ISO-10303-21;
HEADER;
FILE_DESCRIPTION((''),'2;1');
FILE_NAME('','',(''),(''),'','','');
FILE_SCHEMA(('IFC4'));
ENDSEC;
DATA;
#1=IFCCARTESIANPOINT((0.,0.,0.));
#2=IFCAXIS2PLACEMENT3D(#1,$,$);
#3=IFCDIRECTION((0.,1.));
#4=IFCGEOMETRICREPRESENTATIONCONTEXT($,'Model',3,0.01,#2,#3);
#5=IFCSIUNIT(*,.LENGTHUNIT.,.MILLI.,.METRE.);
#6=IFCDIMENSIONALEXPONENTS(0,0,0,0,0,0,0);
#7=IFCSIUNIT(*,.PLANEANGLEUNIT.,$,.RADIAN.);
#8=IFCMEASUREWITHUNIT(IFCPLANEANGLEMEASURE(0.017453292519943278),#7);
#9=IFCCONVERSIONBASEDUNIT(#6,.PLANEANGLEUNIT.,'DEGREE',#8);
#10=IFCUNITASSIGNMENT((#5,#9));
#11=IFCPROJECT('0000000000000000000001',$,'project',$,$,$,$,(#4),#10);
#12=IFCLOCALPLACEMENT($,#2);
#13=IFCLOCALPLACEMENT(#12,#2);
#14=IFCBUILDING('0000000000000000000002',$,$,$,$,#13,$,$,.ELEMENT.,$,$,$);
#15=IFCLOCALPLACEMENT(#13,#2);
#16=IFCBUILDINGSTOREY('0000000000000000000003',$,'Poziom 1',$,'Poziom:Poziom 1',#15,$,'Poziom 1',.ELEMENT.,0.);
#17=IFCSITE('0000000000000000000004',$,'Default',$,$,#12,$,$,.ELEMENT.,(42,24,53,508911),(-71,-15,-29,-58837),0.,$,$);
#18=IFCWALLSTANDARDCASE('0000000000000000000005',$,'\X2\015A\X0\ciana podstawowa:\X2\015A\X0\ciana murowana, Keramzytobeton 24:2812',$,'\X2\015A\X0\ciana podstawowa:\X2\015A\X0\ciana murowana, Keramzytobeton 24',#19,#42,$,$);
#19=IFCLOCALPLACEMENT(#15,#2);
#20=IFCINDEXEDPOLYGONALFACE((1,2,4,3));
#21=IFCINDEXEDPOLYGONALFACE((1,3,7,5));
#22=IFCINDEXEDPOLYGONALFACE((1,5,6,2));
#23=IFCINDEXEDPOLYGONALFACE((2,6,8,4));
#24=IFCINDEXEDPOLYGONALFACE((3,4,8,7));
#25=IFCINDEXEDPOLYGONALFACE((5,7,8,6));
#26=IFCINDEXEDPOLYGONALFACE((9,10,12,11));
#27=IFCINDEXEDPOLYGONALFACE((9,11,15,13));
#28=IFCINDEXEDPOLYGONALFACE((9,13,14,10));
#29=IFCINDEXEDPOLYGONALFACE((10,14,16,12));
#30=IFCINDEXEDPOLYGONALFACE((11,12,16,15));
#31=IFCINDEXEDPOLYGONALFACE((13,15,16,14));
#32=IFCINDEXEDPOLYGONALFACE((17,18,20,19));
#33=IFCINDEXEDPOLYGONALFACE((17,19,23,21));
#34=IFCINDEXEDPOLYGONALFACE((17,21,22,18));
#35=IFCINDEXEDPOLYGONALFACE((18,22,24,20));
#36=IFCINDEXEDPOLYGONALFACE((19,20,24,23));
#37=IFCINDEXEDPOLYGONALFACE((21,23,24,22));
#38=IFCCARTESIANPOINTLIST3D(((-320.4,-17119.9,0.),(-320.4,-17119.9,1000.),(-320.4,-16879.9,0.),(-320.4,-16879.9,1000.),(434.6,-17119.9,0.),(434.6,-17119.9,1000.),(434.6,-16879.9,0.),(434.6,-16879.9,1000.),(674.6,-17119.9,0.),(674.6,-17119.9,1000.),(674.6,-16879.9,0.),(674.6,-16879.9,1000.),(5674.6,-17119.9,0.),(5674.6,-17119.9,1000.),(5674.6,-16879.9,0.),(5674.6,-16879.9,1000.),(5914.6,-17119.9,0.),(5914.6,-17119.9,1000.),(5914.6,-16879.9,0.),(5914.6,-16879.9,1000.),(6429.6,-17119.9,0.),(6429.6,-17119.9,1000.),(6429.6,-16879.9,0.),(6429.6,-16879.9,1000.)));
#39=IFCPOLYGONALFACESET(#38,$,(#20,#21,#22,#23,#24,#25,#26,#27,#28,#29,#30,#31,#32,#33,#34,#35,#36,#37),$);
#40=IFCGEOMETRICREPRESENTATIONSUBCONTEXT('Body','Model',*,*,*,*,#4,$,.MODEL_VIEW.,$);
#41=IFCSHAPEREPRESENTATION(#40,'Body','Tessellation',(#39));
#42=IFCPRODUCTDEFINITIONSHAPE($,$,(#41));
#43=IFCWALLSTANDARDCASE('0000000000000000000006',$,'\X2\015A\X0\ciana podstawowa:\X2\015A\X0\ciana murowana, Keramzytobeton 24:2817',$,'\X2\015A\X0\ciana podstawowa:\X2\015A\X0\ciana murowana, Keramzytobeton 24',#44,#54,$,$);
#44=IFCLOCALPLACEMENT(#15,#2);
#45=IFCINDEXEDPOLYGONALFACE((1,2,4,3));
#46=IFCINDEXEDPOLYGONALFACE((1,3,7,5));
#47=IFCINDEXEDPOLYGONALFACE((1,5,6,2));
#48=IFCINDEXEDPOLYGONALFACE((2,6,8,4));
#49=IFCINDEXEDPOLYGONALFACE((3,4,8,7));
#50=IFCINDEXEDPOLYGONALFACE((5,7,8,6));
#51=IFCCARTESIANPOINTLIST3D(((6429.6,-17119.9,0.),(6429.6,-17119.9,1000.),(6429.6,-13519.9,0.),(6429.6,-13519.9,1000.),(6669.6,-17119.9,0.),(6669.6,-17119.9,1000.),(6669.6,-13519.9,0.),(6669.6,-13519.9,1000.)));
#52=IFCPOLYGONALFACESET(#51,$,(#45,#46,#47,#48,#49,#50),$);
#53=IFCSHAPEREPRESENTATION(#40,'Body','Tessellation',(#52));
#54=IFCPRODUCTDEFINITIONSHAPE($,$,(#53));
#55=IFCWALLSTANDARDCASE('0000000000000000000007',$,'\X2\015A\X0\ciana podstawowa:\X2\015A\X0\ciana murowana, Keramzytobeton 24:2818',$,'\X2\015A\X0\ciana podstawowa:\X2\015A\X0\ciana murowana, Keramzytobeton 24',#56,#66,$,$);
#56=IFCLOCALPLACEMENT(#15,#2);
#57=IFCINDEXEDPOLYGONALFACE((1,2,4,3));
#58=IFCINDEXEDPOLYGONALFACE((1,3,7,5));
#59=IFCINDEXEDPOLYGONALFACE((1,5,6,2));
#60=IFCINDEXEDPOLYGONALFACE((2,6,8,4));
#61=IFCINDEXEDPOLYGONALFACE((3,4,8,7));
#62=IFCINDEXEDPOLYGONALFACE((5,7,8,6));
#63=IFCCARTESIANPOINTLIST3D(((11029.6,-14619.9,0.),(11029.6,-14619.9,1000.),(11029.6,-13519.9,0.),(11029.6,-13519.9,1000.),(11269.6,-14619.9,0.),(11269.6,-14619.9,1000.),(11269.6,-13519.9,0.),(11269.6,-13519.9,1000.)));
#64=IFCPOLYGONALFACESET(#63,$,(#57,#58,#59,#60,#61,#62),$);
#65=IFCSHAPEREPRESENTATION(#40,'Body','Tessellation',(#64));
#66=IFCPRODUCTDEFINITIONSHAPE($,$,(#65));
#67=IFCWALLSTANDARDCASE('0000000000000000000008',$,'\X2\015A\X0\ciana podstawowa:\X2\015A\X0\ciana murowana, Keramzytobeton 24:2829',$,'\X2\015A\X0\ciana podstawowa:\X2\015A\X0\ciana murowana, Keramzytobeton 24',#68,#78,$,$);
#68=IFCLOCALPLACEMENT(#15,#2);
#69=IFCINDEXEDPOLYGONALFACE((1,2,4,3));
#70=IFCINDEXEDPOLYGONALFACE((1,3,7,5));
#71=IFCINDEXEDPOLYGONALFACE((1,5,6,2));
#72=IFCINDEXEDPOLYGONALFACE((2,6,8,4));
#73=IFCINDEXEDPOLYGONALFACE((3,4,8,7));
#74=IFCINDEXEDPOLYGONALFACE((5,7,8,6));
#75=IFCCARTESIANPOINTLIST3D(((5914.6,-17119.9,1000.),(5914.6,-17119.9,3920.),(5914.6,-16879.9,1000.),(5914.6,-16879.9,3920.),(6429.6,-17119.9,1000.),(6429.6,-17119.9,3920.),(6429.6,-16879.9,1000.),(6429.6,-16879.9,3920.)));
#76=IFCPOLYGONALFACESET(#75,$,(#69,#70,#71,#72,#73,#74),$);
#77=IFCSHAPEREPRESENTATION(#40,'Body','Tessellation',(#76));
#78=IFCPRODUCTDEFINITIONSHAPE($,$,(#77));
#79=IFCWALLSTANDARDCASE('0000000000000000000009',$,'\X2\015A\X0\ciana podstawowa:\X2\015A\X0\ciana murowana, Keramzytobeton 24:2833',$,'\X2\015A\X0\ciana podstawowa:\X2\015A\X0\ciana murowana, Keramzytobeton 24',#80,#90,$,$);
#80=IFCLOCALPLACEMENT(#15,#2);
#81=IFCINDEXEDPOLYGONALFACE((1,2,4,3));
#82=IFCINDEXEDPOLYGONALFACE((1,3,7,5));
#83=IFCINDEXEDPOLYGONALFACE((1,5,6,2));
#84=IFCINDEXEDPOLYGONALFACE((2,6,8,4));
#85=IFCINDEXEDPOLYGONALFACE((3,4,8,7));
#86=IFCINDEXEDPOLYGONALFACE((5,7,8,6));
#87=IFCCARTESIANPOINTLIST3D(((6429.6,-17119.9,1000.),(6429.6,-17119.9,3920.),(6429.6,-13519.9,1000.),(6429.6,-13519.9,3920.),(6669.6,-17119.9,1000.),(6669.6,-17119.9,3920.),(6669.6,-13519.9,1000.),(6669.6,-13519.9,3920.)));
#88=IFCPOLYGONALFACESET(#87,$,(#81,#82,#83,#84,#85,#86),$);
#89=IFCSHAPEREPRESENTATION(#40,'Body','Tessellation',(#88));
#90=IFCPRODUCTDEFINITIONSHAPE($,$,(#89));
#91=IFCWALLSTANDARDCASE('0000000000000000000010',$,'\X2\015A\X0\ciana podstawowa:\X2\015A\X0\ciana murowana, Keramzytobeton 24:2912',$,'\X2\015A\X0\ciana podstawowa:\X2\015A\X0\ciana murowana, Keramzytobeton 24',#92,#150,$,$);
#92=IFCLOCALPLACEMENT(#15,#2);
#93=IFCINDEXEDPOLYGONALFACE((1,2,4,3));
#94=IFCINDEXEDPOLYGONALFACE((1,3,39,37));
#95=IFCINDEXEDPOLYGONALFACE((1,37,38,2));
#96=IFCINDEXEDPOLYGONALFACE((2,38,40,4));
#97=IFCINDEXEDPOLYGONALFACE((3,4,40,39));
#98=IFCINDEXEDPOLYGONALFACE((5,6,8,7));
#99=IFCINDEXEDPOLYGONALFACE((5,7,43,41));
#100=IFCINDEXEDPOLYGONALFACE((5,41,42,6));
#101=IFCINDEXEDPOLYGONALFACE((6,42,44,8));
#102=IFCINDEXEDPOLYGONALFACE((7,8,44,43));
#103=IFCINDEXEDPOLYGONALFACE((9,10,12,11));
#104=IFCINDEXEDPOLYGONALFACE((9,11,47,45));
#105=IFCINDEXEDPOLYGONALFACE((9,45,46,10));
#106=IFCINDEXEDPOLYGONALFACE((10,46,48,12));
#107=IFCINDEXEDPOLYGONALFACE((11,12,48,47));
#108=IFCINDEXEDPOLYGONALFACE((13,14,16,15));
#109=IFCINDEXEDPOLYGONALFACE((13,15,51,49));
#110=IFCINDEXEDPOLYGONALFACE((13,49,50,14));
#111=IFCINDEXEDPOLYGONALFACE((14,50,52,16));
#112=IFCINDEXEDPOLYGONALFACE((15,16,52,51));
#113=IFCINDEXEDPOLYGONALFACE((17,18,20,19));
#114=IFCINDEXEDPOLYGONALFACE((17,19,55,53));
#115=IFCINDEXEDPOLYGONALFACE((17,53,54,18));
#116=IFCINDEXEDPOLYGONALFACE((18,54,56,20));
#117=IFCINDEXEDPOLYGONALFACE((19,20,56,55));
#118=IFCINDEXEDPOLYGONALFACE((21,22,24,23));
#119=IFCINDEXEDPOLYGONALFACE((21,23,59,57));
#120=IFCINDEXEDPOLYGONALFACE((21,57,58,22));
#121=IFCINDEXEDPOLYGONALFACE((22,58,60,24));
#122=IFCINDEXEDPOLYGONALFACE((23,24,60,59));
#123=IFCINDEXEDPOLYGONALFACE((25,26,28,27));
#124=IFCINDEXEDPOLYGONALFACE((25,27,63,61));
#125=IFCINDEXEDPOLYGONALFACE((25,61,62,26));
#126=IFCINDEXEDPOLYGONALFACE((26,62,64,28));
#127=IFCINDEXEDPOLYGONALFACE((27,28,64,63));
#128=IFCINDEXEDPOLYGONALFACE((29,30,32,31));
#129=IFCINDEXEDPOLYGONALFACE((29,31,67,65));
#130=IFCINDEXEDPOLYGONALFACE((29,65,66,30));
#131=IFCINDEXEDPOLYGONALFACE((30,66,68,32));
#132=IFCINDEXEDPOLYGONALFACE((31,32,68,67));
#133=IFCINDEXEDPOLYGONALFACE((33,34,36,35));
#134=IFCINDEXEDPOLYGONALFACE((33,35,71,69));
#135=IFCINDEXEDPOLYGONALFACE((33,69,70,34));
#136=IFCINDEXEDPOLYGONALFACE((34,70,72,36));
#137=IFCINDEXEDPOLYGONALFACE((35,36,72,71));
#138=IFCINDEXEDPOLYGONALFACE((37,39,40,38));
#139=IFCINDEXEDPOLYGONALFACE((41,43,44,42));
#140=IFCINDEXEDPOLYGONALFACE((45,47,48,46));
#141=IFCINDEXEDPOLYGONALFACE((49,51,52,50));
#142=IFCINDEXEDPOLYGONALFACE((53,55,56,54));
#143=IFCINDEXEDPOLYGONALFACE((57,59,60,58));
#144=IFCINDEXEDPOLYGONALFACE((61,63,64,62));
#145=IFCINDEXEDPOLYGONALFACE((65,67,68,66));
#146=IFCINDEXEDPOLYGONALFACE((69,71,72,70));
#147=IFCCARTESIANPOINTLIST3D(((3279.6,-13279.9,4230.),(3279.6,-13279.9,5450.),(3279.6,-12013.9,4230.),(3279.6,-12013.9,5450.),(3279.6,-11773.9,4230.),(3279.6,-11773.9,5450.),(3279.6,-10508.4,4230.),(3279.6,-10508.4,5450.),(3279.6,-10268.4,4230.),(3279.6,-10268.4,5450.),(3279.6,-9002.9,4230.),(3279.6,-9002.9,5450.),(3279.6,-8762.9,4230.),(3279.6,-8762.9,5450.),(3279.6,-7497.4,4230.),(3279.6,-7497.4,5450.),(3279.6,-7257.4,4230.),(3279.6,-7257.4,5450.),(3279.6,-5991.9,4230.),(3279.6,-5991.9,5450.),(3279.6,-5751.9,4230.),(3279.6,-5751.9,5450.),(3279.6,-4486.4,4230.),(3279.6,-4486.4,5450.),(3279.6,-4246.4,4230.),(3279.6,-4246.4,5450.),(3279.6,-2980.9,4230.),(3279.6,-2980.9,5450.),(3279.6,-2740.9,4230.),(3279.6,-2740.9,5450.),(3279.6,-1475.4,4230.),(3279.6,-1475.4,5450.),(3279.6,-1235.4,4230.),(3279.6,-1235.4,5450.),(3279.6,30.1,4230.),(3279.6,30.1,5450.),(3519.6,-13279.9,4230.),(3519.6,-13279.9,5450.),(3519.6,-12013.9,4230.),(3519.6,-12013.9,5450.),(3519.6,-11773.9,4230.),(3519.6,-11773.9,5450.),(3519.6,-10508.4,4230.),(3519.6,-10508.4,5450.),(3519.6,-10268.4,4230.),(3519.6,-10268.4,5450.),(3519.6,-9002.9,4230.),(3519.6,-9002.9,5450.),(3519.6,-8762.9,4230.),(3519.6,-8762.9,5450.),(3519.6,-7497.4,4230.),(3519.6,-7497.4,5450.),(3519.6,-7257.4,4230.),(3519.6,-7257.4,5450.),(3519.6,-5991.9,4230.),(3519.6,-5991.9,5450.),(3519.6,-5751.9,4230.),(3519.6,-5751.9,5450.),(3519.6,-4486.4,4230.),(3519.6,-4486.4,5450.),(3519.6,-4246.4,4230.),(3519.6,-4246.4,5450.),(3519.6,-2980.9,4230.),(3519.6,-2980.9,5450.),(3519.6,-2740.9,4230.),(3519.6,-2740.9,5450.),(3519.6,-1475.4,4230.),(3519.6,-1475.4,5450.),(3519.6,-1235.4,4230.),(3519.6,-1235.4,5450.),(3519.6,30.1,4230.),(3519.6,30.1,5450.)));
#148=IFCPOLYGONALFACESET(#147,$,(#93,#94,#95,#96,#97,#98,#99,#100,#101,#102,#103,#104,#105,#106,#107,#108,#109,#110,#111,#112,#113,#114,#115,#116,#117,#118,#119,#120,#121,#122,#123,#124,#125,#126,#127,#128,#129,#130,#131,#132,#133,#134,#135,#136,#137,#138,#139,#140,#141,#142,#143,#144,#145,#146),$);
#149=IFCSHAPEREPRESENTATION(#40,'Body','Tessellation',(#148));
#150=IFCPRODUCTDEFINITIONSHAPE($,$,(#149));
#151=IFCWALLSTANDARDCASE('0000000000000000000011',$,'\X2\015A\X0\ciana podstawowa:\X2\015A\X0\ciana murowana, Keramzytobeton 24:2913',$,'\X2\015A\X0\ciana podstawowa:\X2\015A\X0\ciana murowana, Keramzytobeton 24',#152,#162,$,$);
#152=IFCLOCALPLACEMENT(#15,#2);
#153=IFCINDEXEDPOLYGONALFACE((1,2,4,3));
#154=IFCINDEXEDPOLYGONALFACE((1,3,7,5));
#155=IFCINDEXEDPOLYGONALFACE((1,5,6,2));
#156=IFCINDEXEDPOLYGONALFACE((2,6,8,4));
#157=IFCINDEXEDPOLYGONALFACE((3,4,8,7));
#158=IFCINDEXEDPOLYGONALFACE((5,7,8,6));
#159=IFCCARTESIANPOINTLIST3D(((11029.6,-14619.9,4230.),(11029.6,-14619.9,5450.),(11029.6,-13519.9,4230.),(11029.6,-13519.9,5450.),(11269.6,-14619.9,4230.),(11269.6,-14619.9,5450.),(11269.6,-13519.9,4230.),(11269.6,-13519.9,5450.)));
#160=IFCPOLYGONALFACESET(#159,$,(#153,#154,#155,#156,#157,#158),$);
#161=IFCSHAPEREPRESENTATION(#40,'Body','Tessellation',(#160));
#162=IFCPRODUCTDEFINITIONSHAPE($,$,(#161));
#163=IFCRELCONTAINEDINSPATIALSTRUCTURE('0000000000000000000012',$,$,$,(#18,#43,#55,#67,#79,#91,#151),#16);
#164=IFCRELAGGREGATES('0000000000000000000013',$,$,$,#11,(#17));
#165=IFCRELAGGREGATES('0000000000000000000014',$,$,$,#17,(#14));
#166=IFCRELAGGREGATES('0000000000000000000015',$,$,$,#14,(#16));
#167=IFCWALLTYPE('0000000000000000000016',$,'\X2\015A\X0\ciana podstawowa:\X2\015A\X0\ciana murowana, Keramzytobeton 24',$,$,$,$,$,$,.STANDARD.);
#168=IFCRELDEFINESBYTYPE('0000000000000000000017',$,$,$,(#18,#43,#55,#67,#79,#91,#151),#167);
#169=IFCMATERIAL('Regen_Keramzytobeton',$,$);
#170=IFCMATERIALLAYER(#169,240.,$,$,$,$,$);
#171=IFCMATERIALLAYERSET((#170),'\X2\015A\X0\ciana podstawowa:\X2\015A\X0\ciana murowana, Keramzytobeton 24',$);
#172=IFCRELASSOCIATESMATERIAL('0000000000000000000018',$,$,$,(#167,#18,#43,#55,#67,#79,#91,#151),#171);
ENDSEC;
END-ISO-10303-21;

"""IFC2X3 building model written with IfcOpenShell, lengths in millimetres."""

from ifc_helpers import new_model, entity, si_unit, converted_unit, direction, frame, frame_2d, origin, place, context, subcontext, project, spatial, rectangle, extrude, material, layer, layer_set, layer_usage, type_object, element, save


model = new_model("IFC2X3")

# Units and contexts
model_context = context("Model", 3, precision=0.01, world=origin(), true_north=direction((0.0, 1.0)))
body_context = subcontext(model_context, "Body", "Model", "MODEL_VIEW")
ifc_project = project(units=[si_unit("LENGTHUNIT", "METRE", prefix="MILLI"), converted_unit("PLANEANGLEUNIT", "DEGREE", entity("IfcPlaneAngleMeasure", 0.017453292519943278), si_unit("PLANEANGLEUNIT", "RADIAN"), dimensions=[0, 0, 0, 0, 0, 0, 0])], contexts=[model_context])

# Site, building, storey
site_placement = place(None, origin())
site = spatial("IfcSite", under=ifc_project, at=site_placement, Name="Default", CompositionType="ELEMENT", RefLatitude=(42, 24, 53, 508911), RefLongitude=(-71, -15, -29, -58837), RefElevation=0.0)
building_placement = place(site_placement, origin())
building = spatial("IfcBuilding", under=site, at=building_placement, CompositionType="ELEMENT")
storey_placement = place(building_placement, origin())
storey = spatial("IfcBuildingStorey", under=building, at=storey_placement, Name="Poziom 1", ObjectType="Poziom:Poziom 1", LongName="Poziom 1", CompositionType="ELEMENT", Elevation=0.0)

# Shared definitions
ifc_material_1 = material(Name="Regen_Keramzytobeton")
ifc_layer_1 = layer(ifc_material_1, 240.0)
ifc_layer_set_1 = layer_set([ifc_layer_1], Name="Ściana podstawowa:Ściana murowana, Keramzytobeton 24")
wall_type_1 = type_object("IfcWallType", Name="Ściana podstawowa:Ściana murowana, Keramzytobeton 24", PredefinedType="STANDARD", material=ifc_layer_set_1)

# Wall, openings
ifc_layer_usage_1 = layer_usage(ifc_layer_set_1, "AXIS2", "NEGATIVE", 120.0)
wall_1_placement = place(storey_placement, frame((6429.6, -16999.9, 0.0), z_axis=(0.0, 0.0, 1.0), x_axis=(-1.0, 0.0, 0.0)))
wall_1 = element("IfcWallStandardCase", 1, at=wall_1_placement, inside=storey, type_object=wall_type_1, material=ifc_layer_usage_1, Name="Ściana podstawowa:Ściana murowana, Keramzytobeton 24:2812", ObjectType="Ściana podstawowa:Ściana murowana, Keramzytobeton 24", context=body_context, shape_type="SweptSolid", body=[
    extrude(rectangle(XDim=6750.0, YDim=240.0, at=frame_2d((3375.0, 0.0), x_axis=(-1.0, 0.0))), origin(), (0.0, 0.0, 1.0), 1000.0),
])
opening_1_placement = place(storey_placement, frame((6429.6, -16999.9, 0.0), z_axis=(0.0, 0.0, 1.0), x_axis=(-1.0, 0.0, 0.0)))
element("IfcOpeningElement", 2, at=opening_1_placement, cuts=wall_1, ObjectType="Opening", context=body_context, shape_type="SweptSolid", body=[
    extrude(rectangle(XDim=1000.0, YDim=240.0, at=frame_2d((0.0, 0.0), x_axis=(1.0, 0.0))), frame((5995.0, 0.0, 500.0), z_axis=(-1.0, 0.0, 0.0), x_axis=(0.0, 0.0, 1.0)), (0.0, 0.0, 1.0), 240.0),
])
opening_2_placement = place(storey_placement, frame((6429.6, -16999.9, 0.0), z_axis=(0.0, 0.0, 1.0), x_axis=(-1.0, 0.0, 0.0)))
element("IfcOpeningElement", 3, at=opening_2_placement, cuts=wall_1, ObjectType="Opening", context=body_context, shape_type="SweptSolid", body=[
    extrude(rectangle(XDim=1000.0, YDim=240.0, at=frame_2d((0.0, 0.0), x_axis=(1.0, 0.0))), frame((755.0, 0.0, 500.0), z_axis=(-1.0, 0.0, 0.0), x_axis=(0.0, 0.0, 1.0)), (0.0, 0.0, 1.0), 240.0),
])

# Walls
ifc_layer_usage_2 = layer_usage(ifc_layer_set_1, "AXIS2", "NEGATIVE", 120.0)
wall_2_placement = place(storey_placement, frame((6549.6, -13519.9, 0.0), z_axis=(0.0, 0.0, 1.0), x_axis=(0.0, -1.0, 0.0)))
element("IfcWallStandardCase", 4, at=wall_2_placement, inside=storey, type_object=wall_type_1, material=ifc_layer_usage_2, Name="Ściana podstawowa:Ściana murowana, Keramzytobeton 24:2817", ObjectType="Ściana podstawowa:Ściana murowana, Keramzytobeton 24", context=body_context, shape_type="SweptSolid", body=[
    extrude(rectangle(XDim=3600.0, YDim=240.0, at=frame_2d((1800.0, 0.0), x_axis=(-1.0, 0.0))), origin(), (0.0, 0.0, 1.0), 1000.0),
])
ifc_layer_usage_3 = layer_usage(ifc_layer_set_1, "AXIS2", "NEGATIVE", 120.0)
wall_3_placement = place(storey_placement, frame((11149.6, -13519.9, 0.0), z_axis=(0.0, 0.0, 1.0), x_axis=(0.0, -1.0, 0.0)))
element("IfcWallStandardCase", 5, at=wall_3_placement, inside=storey, type_object=wall_type_1, material=ifc_layer_usage_3, Name="Ściana podstawowa:Ściana murowana, Keramzytobeton 24:2818", ObjectType="Ściana podstawowa:Ściana murowana, Keramzytobeton 24", context=body_context, shape_type="SweptSolid", body=[
    extrude(rectangle(XDim=1100.0, YDim=240.0, at=frame_2d((550.0, 0.0), x_axis=(-1.0, 0.0))), origin(), (0.0, 0.0, 1.0), 1000.0),
])
ifc_layer_usage_4 = layer_usage(ifc_layer_set_1, "AXIS2", "NEGATIVE", 120.0)
wall_4_placement = place(storey_placement, frame((6429.6, -16999.9, 1000.0), z_axis=(0.0, 0.0, 1.0), x_axis=(-1.0, 0.0, 0.0)))
element("IfcWallStandardCase", 6, at=wall_4_placement, inside=storey, type_object=wall_type_1, material=ifc_layer_usage_4, Name="Ściana podstawowa:Ściana murowana, Keramzytobeton 24:2829", ObjectType="Ściana podstawowa:Ściana murowana, Keramzytobeton 24", context=body_context, shape_type="SweptSolid", body=[
    extrude(rectangle(XDim=515.0, YDim=240.0, at=frame_2d((257.5, 0.0), x_axis=(-1.0, 0.0))), origin(), (0.0, 0.0, 1.0), 2920.0),
])
ifc_layer_usage_5 = layer_usage(ifc_layer_set_1, "AXIS2", "NEGATIVE", 120.0)
wall_5_placement = place(storey_placement, frame((6549.6, -13519.9, 1000.0), z_axis=(0.0, 0.0, 1.0), x_axis=(0.0, -1.0, 0.0)))
element("IfcWallStandardCase", 7, at=wall_5_placement, inside=storey, type_object=wall_type_1, material=ifc_layer_usage_5, Name="Ściana podstawowa:Ściana murowana, Keramzytobeton 24:2833", ObjectType="Ściana podstawowa:Ściana murowana, Keramzytobeton 24", context=body_context, shape_type="SweptSolid", body=[
    extrude(rectangle(XDim=3600.0, YDim=240.0, at=frame_2d((1800.0, 0.0), x_axis=(-1.0, 0.0))), origin(), (0.0, 0.0, 1.0), 2920.0),
])

# Wall, openings
ifc_layer_usage_6 = layer_usage(ifc_layer_set_1, "AXIS2", "NEGATIVE", 120.0)
wall_6_placement = place(storey_placement, frame((3399.6, -13279.9, 4230.0), z_axis=(0.0, 0.0, 1.0), x_axis=(0.0, 1.0, 0.0)))
wall_6 = element("IfcWallStandardCase", 8, at=wall_6_placement, inside=storey, type_object=wall_type_1, material=ifc_layer_usage_6, Name="Ściana podstawowa:Ściana murowana, Keramzytobeton 24:2912", ObjectType="Ściana podstawowa:Ściana murowana, Keramzytobeton 24", context=body_context, shape_type="SweptSolid", body=[
    extrude(rectangle(XDim=13310.0, YDim=240.0, at=frame_2d((6655.0, 0.0), x_axis=(-1.0, 0.0))), origin(), (0.0, 0.0, 1.0), 1220.0),
])
opening_3_placement = place(storey_placement, frame((3399.6, -13279.9, 4230.0), z_axis=(0.0, 0.0, 1.0), x_axis=(0.0, 1.0, 0.0)))
element("IfcOpeningElement", 9, at=opening_3_placement, cuts=wall_6, ObjectType="Opening", context=body_context, shape_type="SweptSolid", body=[
    extrude(rectangle(XDim=1220.0, YDim=240.0, at=frame_2d((0.0, 0.0), x_axis=(1.0, 0.0))), frame((11804.5, 0.0, 610.0), z_axis=(1.0, 0.0, 0.0), x_axis=(0.0, 0.0, -1.0)), (0.0, 0.0, 1.0), 240.0),
])
opening_4_placement = place(storey_placement, frame((3399.6, -13279.9, 4230.0), z_axis=(0.0, 0.0, 1.0), x_axis=(0.0, 1.0, 0.0)))
element("IfcOpeningElement", 10, at=opening_4_placement, cuts=wall_6, ObjectType="Opening", context=body_context, shape_type="SweptSolid", body=[
    extrude(rectangle(XDim=1220.0, YDim=240.0, at=frame_2d((0.0, 0.0), x_axis=(1.0, 0.0))), frame((10299.0, 0.0, 610.0), z_axis=(1.0, 0.0, 0.0), x_axis=(0.0, 0.0, -1.0)), (0.0, 0.0, 1.0), 240.0),
])
opening_5_placement = place(storey_placement, frame((3399.6, -13279.9, 4230.0), z_axis=(0.0, 0.0, 1.0), x_axis=(0.0, 1.0, 0.0)))
element("IfcOpeningElement", 11, at=opening_5_placement, cuts=wall_6, ObjectType="Opening", context=body_context, shape_type="SweptSolid", body=[
    extrude(rectangle(XDim=1220.0, YDim=240.0, at=frame_2d((0.0, 0.0), x_axis=(1.0, 0.0))), frame((8793.5, 0.0, 610.0), z_axis=(1.0, 0.0, 0.0), x_axis=(0.0, 0.0, -1.0)), (0.0, 0.0, 1.0), 240.0),
])
opening_6_placement = place(storey_placement, frame((3399.6, -13279.9, 4230.0), z_axis=(0.0, 0.0, 1.0), x_axis=(0.0, 1.0, 0.0)))
element("IfcOpeningElement", 12, at=opening_6_placement, cuts=wall_6, ObjectType="Opening", context=body_context, shape_type="SweptSolid", body=[
    extrude(rectangle(XDim=1220.0, YDim=240.0, at=frame_2d((0.0, 0.0), x_axis=(1.0, 0.0))), frame((7288.0, 0.0, 610.0), z_axis=(1.0, 0.0, 0.0), x_axis=(0.0, 0.0, -1.0)), (0.0, 0.0, 1.0), 240.0),
])
opening_7_placement = place(storey_placement, frame((3399.6, -13279.9, 4230.0), z_axis=(0.0, 0.0, 1.0), x_axis=(0.0, 1.0, 0.0)))
element("IfcOpeningElement", 13, at=opening_7_placement, cuts=wall_6, ObjectType="Opening", context=body_context, shape_type="SweptSolid", body=[
    extrude(rectangle(XDim=1220.0, YDim=240.0, at=frame_2d((0.0, 0.0), x_axis=(1.0, 0.0))), frame((5782.5, 0.0, 610.0), z_axis=(1.0, 0.0, 0.0), x_axis=(0.0, 0.0, -1.0)), (0.0, 0.0, 1.0), 240.0),
])
opening_8_placement = place(storey_placement, frame((3399.6, -13279.9, 4230.0), z_axis=(0.0, 0.0, 1.0), x_axis=(0.0, 1.0, 0.0)))
element("IfcOpeningElement", 14, at=opening_8_placement, cuts=wall_6, ObjectType="Opening", context=body_context, shape_type="SweptSolid", body=[
    extrude(rectangle(XDim=1220.0, YDim=240.0, at=frame_2d((0.0, 0.0), x_axis=(1.0, 0.0))), frame((4277.0, 0.0, 610.0), z_axis=(1.0, 0.0, 0.0), x_axis=(0.0, 0.0, -1.0)), (0.0, 0.0, 1.0), 240.0),
])
opening_9_placement = place(storey_placement, frame((3399.6, -13279.9, 4230.0), z_axis=(0.0, 0.0, 1.0), x_axis=(0.0, 1.0, 0.0)))
element("IfcOpeningElement", 15, at=opening_9_placement, cuts=wall_6, ObjectType="Opening", context=body_context, shape_type="SweptSolid", body=[
    extrude(rectangle(XDim=1220.0, YDim=240.0, at=frame_2d((0.0, 0.0), x_axis=(1.0, 0.0))), frame((2771.5, 0.0, 610.0), z_axis=(1.0, 0.0, 0.0), x_axis=(0.0, 0.0, -1.0)), (0.0, 0.0, 1.0), 240.0),
])
opening_10_placement = place(storey_placement, frame((3399.6, -13279.9, 4230.0), z_axis=(0.0, 0.0, 1.0), x_axis=(0.0, 1.0, 0.0)))
element("IfcOpeningElement", 16, at=opening_10_placement, cuts=wall_6, ObjectType="Opening", context=body_context, shape_type="SweptSolid", body=[
    extrude(rectangle(XDim=1220.0, YDim=240.0, at=frame_2d((0.0, 0.0), x_axis=(1.0, 0.0))), frame((1266.0, 0.0, 610.0), z_axis=(1.0, 0.0, 0.0), x_axis=(0.0, 0.0, -1.0)), (0.0, 0.0, 1.0), 240.0),
])

# Wall
ifc_layer_usage_7 = layer_usage(ifc_layer_set_1, "AXIS2", "NEGATIVE", 120.0)
wall_7_placement = place(storey_placement, frame((11149.6, -14619.9, 4230.0), z_axis=(0.0, 0.0, 1.0), x_axis=(0.0, 1.0, 0.0)))
element("IfcWallStandardCase", 17, at=wall_7_placement, inside=storey, type_object=wall_type_1, material=ifc_layer_usage_7, Name="Ściana podstawowa:Ściana murowana, Keramzytobeton 24:2913", ObjectType="Ściana podstawowa:Ściana murowana, Keramzytobeton 24", context=body_context, shape_type="SweptSolid", body=[
    extrude(rectangle(XDim=1100.0, YDim=240.0, at=frame_2d((550.0, 0.0), x_axis=(-1.0, 0.0))), origin(), (0.0, 0.0, 1.0), 1220.0),
])

save(model, "model.ifc")
